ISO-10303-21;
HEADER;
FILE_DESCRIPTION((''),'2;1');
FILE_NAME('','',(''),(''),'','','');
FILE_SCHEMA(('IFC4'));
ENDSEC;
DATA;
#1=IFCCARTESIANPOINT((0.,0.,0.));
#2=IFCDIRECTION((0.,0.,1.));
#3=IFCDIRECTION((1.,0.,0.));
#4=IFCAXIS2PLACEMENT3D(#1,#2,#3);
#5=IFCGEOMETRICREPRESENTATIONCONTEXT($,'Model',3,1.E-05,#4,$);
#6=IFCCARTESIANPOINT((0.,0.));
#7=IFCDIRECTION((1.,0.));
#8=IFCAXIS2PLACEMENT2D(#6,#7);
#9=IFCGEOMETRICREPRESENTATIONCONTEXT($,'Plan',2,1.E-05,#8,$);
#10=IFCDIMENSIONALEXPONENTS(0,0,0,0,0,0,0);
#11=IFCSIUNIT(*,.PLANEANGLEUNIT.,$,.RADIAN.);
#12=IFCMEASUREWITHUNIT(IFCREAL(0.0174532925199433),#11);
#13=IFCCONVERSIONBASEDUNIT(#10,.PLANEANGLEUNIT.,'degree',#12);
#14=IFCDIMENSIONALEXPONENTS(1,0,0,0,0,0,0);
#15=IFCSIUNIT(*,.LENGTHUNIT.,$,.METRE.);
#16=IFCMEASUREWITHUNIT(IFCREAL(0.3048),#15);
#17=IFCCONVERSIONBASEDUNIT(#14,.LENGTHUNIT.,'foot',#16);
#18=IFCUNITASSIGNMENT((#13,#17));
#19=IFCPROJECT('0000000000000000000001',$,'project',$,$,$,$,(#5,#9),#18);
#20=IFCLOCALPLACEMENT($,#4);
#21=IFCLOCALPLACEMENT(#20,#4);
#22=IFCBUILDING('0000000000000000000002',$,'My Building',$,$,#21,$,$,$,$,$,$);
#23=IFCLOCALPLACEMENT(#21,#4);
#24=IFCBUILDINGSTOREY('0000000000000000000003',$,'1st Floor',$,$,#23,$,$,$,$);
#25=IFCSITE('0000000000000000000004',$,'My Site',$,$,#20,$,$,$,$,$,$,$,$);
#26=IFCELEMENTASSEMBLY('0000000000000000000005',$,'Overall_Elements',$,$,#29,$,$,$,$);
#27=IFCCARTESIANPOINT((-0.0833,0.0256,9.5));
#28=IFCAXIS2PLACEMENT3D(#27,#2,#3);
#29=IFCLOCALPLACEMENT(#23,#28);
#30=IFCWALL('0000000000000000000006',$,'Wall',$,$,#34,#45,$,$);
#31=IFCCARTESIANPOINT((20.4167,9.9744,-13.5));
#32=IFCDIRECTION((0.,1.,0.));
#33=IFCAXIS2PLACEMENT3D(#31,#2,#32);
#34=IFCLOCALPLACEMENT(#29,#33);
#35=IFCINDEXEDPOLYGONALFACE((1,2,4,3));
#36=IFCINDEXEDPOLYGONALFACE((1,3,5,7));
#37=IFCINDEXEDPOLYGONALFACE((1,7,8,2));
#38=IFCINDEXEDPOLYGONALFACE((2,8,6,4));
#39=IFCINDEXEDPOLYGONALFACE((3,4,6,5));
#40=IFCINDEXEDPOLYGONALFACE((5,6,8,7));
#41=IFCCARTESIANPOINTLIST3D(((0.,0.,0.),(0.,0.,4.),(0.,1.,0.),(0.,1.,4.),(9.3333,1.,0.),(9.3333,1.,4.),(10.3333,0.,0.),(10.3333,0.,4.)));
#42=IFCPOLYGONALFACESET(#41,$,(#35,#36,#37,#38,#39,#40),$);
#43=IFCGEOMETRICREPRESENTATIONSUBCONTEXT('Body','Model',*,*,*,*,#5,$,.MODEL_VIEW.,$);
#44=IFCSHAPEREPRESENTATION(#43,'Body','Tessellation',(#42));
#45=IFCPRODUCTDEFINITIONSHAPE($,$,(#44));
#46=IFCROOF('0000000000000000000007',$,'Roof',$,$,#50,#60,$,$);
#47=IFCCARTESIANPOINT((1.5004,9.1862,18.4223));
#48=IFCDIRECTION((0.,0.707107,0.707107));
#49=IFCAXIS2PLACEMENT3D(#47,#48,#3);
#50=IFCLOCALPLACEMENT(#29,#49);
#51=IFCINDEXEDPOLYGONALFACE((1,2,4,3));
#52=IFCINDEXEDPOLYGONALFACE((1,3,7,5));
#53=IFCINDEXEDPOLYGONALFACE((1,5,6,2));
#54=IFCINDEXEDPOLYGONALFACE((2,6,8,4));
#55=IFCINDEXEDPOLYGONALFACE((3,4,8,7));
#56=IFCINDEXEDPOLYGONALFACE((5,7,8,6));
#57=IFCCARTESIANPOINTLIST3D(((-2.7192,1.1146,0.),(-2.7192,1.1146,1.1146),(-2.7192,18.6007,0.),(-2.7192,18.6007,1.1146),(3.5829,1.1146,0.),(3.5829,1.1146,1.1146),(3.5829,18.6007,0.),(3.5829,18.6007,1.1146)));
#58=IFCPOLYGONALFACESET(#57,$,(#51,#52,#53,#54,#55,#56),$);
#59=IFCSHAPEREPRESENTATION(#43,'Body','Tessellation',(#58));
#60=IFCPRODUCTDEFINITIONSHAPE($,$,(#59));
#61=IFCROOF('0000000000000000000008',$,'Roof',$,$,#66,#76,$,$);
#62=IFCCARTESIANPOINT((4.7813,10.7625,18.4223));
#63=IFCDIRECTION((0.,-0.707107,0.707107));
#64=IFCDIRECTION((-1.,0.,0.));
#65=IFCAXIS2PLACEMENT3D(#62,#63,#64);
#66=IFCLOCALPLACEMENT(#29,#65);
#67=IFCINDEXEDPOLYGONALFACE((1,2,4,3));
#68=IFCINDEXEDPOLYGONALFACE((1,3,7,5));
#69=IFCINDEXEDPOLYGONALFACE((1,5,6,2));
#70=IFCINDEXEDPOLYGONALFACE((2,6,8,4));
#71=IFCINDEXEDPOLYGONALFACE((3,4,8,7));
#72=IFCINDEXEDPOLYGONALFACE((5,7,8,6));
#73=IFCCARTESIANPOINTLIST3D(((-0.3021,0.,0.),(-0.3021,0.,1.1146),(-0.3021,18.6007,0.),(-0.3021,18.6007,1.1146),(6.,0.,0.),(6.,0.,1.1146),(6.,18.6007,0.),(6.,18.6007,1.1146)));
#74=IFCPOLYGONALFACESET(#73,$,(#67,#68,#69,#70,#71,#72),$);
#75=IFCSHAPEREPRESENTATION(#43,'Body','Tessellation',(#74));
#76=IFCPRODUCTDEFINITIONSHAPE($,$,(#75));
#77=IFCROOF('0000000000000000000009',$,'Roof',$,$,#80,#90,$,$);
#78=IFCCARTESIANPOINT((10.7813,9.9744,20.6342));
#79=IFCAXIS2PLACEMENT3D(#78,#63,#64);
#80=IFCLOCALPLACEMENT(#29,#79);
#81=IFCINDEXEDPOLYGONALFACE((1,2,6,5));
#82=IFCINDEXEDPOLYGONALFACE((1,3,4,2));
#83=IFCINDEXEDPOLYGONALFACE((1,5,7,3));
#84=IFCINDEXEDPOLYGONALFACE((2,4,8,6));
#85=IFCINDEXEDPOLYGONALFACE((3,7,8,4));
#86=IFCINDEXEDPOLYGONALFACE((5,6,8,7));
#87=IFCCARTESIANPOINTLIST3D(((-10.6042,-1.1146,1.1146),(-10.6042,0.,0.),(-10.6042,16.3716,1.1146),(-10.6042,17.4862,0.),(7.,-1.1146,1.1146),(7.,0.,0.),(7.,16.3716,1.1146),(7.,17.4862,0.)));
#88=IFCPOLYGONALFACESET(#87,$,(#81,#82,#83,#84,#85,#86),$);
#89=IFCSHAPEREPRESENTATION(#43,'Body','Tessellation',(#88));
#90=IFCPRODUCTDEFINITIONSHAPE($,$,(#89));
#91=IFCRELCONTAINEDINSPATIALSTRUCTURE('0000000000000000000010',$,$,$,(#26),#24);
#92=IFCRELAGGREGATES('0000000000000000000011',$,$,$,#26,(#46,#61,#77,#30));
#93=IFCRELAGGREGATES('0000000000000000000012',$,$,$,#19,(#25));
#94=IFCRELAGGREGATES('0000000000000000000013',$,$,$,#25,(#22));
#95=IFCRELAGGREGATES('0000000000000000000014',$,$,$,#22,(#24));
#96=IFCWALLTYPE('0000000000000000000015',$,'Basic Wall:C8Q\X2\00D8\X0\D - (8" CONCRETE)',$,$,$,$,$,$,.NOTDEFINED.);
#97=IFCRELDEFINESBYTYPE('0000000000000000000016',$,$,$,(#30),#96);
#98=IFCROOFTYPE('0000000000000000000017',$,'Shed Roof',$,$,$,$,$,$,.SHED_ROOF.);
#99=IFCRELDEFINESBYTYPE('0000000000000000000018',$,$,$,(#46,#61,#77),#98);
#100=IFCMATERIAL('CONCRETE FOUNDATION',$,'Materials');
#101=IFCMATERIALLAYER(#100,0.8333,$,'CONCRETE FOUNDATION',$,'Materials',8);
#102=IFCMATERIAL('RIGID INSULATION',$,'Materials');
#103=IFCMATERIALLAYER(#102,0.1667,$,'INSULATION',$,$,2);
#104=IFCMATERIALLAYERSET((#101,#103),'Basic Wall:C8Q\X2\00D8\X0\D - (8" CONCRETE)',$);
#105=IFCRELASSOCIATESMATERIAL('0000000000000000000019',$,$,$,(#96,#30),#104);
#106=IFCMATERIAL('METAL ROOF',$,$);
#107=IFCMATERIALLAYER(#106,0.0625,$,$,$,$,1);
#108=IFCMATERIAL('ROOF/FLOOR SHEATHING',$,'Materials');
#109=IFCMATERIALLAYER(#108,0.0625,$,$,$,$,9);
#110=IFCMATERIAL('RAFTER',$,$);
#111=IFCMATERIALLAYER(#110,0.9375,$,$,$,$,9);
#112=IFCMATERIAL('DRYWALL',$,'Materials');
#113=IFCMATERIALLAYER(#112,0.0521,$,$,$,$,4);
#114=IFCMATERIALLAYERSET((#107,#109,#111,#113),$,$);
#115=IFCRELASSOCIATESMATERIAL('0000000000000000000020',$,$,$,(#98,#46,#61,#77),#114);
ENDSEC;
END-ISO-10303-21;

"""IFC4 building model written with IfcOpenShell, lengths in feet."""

from ifc_helpers import new_model, entity, si_unit, converted_unit, frame, origin_with_axes, origin_2d_with_axis, place, context, subcontext, project, spatial, indexed_curve, outline, extrude, clip, halfspace, material, layer, layer_set, layer_usage, type_object, element, aggregate, save


model = new_model("IFC4")

# Units and contexts
model_context = context("Model", 3, precision=1e-05, world=origin_with_axes())
plan_context = context("Plan", 2, precision=1e-05, world=origin_2d_with_axis())
body_context = subcontext(model_context, "Body", "Model", "MODEL_VIEW")
ifc_project = project(units=[converted_unit("PLANEANGLEUNIT", "degree", entity("IfcReal", 0.0174532925199433), si_unit("PLANEANGLEUNIT", "RADIAN"), dimensions=[0, 0, 0, 0, 0, 0, 0]), converted_unit("LENGTHUNIT", "foot", entity("IfcReal", 0.3048), si_unit("LENGTHUNIT", "METRE"), dimensions=[1, 0, 0, 0, 0, 0, 0])], contexts=[model_context, plan_context])

# Site, building, storey
site_placement = place(None, origin_with_axes())
site = spatial("IfcSite", under=ifc_project, at=site_placement, Name="My Site")
building_placement = place(site_placement, origin_with_axes())
building = spatial("IfcBuilding", under=site, at=building_placement, Name="My Building")
storey_placement = place(building_placement, origin_with_axes())
storey = spatial("IfcBuildingStorey", under=building, at=storey_placement, Name="1st Floor")

# Element assembly, wall, roofs
assembly_placement = place(storey_placement, frame((-0.0833, 0.0256, 9.5), z_axis=(0.0, 0.0, 1.0), x_axis=(1.0, 0.0, 0.0)))
assembly = element("IfcElementAssembly", 1, at=assembly_placement, inside=storey, Name="Overall_Elements")
ifc_material_1 = material(Name="ROOF/FLOOR SHEATHING", Category="Materials")
ifc_material_2 = material(Name="DRYWALL", Category="Materials")
ifc_material_3 = material(Name="RIGID INSULATION", Category="Materials")
ifc_material_4 = material(Name="CONCRETE FOUNDATION", Category="Materials")
ifc_layer_1 = layer(ifc_material_4, 0.8333, Name="CONCRETE FOUNDATION", Category="Materials", Priority=8)
ifc_layer_2 = layer(ifc_material_3, 0.1667, Name="INSULATION", Priority=2)
ifc_layer_set_1 = layer_set([ifc_layer_1, ifc_layer_2], Name="Basic Wall:C8QØD - (8\" CONCRETE)")
wall_type_1 = type_object("IfcWallType", Name="Basic Wall:C8QØD - (8\" CONCRETE)", PredefinedType="NOTDEFINED", material=ifc_layer_set_1)
ifc_layer_usage_1 = layer_usage(ifc_layer_set_1, "AXIS2", "POSITIVE", 0.0)
wall_1_placement = place(assembly_placement, frame((20.4167, 9.9744, -13.5), z_axis=(0.0, 0.0, 1.0), x_axis=(0.0, 1.0, 0.0)))
wall_1 = element("IfcWall", 2, at=wall_1_placement, type_object=wall_type_1, material=ifc_layer_usage_1, Name="Wall", context=body_context, shape_type="Clipping", body=[
    clip(extrude(outline(indexed_curve([(0.0, 0.0), (0.0, 1.0), (10.3333, 1.0), (10.3333, 0.0), (0.0, 0.0)], self_intersect=False)), origin_with_axes(), (0.0, 0.0, 1.0), 4.0), halfspace(frame((10.3333, 0.0, 4.0), z_axis=(0.707106, 0.707107, 0.0), x_axis=(0.707107, -0.707106, 0.0)), False)),
])
ifc_material_5 = material(Name="METAL ROOF")
ifc_layer_3 = layer(ifc_material_5, 0.0625, Priority=1)
ifc_layer_4 = layer(ifc_material_1, 0.0625, Priority=9)
ifc_material_6 = material(Name="RAFTER")
ifc_layer_5 = layer(ifc_material_6, 0.9375, Priority=9)
ifc_layer_6 = layer(ifc_material_2, 0.0521, Priority=4)
ifc_layer_set_2 = layer_set([ifc_layer_3, ifc_layer_4, ifc_layer_5, ifc_layer_6])
ifc_layer_usage_2 = layer_usage(ifc_layer_set_2, "AXIS3", "POSITIVE", 0.0)
roof_type = type_object("IfcRoofType", Name="Shed Roof", PredefinedType="SHED_ROOF", material=ifc_layer_set_2)
roof_1_placement = place(assembly_placement, frame((1.5004, 9.1862, 18.4223), z_axis=(0.0, 0.707107, 0.707107), x_axis=(1.0, 0.0, 0.0)))
roof_1 = element("IfcRoof", 3, at=roof_1_placement, type_object=roof_type, material=ifc_layer_usage_2, Name="Roof", context=body_context, shape_type="SweptSolid", body=[
    extrude(outline(indexed_curve([(3.5829, 1.1146), (3.5829, 18.6007), (-2.7192, 18.6007), (-2.7192, 1.1146), (3.5829, 1.1146)])), None, (0.0, 0.0, 1.0), 1.1146),
])
ifc_layer_usage_3 = layer_usage(ifc_layer_set_2, "AXIS3", "POSITIVE", 0.0)
roof_2_placement = place(assembly_placement, frame((4.7813, 10.7625, 18.4223), z_axis=(0.0, -0.707107, 0.707107), x_axis=(-1.0, 0.0, 0.0)))
roof_2 = element("IfcRoof", 4, at=roof_2_placement, type_object=roof_type, material=ifc_layer_usage_3, Name="Roof", context=body_context, shape_type="SweptSolid", body=[
    extrude(outline(indexed_curve([(6.0, 18.6007), (-0.3021, 18.6007), (-0.3021, 0.0), (6.0, 0.0), (6.0, 18.6007)])), None, (0.0, 0.0, 1.0), 1.1146),
])
ifc_layer_usage_4 = layer_usage(ifc_layer_set_2, "AXIS3", "POSITIVE", 0.0)
roof_3_placement = place(assembly_placement, frame((10.7813, 9.9744, 20.6342), z_axis=(0.0, -0.707107, 0.707107), x_axis=(-1.0, 0.0, 0.0)))
roof_3 = element("IfcRoof", 5, at=roof_3_placement, type_object=roof_type, material=ifc_layer_usage_4, Name="Roof", context=body_context, shape_type="SweptSolid", body=[
    extrude(outline(indexed_curve([(-10.6042, 0.0), (7.0, 0.0), (7.0, 17.4862), (-10.6042, 17.4862), (-10.6042, 0.0)])), None, (0.0, -0.707107, 0.707107), 1.5763),
])
aggregate(assembly, [roof_1, roof_2, roof_3, wall_1])

save(model, "model.ifc")
